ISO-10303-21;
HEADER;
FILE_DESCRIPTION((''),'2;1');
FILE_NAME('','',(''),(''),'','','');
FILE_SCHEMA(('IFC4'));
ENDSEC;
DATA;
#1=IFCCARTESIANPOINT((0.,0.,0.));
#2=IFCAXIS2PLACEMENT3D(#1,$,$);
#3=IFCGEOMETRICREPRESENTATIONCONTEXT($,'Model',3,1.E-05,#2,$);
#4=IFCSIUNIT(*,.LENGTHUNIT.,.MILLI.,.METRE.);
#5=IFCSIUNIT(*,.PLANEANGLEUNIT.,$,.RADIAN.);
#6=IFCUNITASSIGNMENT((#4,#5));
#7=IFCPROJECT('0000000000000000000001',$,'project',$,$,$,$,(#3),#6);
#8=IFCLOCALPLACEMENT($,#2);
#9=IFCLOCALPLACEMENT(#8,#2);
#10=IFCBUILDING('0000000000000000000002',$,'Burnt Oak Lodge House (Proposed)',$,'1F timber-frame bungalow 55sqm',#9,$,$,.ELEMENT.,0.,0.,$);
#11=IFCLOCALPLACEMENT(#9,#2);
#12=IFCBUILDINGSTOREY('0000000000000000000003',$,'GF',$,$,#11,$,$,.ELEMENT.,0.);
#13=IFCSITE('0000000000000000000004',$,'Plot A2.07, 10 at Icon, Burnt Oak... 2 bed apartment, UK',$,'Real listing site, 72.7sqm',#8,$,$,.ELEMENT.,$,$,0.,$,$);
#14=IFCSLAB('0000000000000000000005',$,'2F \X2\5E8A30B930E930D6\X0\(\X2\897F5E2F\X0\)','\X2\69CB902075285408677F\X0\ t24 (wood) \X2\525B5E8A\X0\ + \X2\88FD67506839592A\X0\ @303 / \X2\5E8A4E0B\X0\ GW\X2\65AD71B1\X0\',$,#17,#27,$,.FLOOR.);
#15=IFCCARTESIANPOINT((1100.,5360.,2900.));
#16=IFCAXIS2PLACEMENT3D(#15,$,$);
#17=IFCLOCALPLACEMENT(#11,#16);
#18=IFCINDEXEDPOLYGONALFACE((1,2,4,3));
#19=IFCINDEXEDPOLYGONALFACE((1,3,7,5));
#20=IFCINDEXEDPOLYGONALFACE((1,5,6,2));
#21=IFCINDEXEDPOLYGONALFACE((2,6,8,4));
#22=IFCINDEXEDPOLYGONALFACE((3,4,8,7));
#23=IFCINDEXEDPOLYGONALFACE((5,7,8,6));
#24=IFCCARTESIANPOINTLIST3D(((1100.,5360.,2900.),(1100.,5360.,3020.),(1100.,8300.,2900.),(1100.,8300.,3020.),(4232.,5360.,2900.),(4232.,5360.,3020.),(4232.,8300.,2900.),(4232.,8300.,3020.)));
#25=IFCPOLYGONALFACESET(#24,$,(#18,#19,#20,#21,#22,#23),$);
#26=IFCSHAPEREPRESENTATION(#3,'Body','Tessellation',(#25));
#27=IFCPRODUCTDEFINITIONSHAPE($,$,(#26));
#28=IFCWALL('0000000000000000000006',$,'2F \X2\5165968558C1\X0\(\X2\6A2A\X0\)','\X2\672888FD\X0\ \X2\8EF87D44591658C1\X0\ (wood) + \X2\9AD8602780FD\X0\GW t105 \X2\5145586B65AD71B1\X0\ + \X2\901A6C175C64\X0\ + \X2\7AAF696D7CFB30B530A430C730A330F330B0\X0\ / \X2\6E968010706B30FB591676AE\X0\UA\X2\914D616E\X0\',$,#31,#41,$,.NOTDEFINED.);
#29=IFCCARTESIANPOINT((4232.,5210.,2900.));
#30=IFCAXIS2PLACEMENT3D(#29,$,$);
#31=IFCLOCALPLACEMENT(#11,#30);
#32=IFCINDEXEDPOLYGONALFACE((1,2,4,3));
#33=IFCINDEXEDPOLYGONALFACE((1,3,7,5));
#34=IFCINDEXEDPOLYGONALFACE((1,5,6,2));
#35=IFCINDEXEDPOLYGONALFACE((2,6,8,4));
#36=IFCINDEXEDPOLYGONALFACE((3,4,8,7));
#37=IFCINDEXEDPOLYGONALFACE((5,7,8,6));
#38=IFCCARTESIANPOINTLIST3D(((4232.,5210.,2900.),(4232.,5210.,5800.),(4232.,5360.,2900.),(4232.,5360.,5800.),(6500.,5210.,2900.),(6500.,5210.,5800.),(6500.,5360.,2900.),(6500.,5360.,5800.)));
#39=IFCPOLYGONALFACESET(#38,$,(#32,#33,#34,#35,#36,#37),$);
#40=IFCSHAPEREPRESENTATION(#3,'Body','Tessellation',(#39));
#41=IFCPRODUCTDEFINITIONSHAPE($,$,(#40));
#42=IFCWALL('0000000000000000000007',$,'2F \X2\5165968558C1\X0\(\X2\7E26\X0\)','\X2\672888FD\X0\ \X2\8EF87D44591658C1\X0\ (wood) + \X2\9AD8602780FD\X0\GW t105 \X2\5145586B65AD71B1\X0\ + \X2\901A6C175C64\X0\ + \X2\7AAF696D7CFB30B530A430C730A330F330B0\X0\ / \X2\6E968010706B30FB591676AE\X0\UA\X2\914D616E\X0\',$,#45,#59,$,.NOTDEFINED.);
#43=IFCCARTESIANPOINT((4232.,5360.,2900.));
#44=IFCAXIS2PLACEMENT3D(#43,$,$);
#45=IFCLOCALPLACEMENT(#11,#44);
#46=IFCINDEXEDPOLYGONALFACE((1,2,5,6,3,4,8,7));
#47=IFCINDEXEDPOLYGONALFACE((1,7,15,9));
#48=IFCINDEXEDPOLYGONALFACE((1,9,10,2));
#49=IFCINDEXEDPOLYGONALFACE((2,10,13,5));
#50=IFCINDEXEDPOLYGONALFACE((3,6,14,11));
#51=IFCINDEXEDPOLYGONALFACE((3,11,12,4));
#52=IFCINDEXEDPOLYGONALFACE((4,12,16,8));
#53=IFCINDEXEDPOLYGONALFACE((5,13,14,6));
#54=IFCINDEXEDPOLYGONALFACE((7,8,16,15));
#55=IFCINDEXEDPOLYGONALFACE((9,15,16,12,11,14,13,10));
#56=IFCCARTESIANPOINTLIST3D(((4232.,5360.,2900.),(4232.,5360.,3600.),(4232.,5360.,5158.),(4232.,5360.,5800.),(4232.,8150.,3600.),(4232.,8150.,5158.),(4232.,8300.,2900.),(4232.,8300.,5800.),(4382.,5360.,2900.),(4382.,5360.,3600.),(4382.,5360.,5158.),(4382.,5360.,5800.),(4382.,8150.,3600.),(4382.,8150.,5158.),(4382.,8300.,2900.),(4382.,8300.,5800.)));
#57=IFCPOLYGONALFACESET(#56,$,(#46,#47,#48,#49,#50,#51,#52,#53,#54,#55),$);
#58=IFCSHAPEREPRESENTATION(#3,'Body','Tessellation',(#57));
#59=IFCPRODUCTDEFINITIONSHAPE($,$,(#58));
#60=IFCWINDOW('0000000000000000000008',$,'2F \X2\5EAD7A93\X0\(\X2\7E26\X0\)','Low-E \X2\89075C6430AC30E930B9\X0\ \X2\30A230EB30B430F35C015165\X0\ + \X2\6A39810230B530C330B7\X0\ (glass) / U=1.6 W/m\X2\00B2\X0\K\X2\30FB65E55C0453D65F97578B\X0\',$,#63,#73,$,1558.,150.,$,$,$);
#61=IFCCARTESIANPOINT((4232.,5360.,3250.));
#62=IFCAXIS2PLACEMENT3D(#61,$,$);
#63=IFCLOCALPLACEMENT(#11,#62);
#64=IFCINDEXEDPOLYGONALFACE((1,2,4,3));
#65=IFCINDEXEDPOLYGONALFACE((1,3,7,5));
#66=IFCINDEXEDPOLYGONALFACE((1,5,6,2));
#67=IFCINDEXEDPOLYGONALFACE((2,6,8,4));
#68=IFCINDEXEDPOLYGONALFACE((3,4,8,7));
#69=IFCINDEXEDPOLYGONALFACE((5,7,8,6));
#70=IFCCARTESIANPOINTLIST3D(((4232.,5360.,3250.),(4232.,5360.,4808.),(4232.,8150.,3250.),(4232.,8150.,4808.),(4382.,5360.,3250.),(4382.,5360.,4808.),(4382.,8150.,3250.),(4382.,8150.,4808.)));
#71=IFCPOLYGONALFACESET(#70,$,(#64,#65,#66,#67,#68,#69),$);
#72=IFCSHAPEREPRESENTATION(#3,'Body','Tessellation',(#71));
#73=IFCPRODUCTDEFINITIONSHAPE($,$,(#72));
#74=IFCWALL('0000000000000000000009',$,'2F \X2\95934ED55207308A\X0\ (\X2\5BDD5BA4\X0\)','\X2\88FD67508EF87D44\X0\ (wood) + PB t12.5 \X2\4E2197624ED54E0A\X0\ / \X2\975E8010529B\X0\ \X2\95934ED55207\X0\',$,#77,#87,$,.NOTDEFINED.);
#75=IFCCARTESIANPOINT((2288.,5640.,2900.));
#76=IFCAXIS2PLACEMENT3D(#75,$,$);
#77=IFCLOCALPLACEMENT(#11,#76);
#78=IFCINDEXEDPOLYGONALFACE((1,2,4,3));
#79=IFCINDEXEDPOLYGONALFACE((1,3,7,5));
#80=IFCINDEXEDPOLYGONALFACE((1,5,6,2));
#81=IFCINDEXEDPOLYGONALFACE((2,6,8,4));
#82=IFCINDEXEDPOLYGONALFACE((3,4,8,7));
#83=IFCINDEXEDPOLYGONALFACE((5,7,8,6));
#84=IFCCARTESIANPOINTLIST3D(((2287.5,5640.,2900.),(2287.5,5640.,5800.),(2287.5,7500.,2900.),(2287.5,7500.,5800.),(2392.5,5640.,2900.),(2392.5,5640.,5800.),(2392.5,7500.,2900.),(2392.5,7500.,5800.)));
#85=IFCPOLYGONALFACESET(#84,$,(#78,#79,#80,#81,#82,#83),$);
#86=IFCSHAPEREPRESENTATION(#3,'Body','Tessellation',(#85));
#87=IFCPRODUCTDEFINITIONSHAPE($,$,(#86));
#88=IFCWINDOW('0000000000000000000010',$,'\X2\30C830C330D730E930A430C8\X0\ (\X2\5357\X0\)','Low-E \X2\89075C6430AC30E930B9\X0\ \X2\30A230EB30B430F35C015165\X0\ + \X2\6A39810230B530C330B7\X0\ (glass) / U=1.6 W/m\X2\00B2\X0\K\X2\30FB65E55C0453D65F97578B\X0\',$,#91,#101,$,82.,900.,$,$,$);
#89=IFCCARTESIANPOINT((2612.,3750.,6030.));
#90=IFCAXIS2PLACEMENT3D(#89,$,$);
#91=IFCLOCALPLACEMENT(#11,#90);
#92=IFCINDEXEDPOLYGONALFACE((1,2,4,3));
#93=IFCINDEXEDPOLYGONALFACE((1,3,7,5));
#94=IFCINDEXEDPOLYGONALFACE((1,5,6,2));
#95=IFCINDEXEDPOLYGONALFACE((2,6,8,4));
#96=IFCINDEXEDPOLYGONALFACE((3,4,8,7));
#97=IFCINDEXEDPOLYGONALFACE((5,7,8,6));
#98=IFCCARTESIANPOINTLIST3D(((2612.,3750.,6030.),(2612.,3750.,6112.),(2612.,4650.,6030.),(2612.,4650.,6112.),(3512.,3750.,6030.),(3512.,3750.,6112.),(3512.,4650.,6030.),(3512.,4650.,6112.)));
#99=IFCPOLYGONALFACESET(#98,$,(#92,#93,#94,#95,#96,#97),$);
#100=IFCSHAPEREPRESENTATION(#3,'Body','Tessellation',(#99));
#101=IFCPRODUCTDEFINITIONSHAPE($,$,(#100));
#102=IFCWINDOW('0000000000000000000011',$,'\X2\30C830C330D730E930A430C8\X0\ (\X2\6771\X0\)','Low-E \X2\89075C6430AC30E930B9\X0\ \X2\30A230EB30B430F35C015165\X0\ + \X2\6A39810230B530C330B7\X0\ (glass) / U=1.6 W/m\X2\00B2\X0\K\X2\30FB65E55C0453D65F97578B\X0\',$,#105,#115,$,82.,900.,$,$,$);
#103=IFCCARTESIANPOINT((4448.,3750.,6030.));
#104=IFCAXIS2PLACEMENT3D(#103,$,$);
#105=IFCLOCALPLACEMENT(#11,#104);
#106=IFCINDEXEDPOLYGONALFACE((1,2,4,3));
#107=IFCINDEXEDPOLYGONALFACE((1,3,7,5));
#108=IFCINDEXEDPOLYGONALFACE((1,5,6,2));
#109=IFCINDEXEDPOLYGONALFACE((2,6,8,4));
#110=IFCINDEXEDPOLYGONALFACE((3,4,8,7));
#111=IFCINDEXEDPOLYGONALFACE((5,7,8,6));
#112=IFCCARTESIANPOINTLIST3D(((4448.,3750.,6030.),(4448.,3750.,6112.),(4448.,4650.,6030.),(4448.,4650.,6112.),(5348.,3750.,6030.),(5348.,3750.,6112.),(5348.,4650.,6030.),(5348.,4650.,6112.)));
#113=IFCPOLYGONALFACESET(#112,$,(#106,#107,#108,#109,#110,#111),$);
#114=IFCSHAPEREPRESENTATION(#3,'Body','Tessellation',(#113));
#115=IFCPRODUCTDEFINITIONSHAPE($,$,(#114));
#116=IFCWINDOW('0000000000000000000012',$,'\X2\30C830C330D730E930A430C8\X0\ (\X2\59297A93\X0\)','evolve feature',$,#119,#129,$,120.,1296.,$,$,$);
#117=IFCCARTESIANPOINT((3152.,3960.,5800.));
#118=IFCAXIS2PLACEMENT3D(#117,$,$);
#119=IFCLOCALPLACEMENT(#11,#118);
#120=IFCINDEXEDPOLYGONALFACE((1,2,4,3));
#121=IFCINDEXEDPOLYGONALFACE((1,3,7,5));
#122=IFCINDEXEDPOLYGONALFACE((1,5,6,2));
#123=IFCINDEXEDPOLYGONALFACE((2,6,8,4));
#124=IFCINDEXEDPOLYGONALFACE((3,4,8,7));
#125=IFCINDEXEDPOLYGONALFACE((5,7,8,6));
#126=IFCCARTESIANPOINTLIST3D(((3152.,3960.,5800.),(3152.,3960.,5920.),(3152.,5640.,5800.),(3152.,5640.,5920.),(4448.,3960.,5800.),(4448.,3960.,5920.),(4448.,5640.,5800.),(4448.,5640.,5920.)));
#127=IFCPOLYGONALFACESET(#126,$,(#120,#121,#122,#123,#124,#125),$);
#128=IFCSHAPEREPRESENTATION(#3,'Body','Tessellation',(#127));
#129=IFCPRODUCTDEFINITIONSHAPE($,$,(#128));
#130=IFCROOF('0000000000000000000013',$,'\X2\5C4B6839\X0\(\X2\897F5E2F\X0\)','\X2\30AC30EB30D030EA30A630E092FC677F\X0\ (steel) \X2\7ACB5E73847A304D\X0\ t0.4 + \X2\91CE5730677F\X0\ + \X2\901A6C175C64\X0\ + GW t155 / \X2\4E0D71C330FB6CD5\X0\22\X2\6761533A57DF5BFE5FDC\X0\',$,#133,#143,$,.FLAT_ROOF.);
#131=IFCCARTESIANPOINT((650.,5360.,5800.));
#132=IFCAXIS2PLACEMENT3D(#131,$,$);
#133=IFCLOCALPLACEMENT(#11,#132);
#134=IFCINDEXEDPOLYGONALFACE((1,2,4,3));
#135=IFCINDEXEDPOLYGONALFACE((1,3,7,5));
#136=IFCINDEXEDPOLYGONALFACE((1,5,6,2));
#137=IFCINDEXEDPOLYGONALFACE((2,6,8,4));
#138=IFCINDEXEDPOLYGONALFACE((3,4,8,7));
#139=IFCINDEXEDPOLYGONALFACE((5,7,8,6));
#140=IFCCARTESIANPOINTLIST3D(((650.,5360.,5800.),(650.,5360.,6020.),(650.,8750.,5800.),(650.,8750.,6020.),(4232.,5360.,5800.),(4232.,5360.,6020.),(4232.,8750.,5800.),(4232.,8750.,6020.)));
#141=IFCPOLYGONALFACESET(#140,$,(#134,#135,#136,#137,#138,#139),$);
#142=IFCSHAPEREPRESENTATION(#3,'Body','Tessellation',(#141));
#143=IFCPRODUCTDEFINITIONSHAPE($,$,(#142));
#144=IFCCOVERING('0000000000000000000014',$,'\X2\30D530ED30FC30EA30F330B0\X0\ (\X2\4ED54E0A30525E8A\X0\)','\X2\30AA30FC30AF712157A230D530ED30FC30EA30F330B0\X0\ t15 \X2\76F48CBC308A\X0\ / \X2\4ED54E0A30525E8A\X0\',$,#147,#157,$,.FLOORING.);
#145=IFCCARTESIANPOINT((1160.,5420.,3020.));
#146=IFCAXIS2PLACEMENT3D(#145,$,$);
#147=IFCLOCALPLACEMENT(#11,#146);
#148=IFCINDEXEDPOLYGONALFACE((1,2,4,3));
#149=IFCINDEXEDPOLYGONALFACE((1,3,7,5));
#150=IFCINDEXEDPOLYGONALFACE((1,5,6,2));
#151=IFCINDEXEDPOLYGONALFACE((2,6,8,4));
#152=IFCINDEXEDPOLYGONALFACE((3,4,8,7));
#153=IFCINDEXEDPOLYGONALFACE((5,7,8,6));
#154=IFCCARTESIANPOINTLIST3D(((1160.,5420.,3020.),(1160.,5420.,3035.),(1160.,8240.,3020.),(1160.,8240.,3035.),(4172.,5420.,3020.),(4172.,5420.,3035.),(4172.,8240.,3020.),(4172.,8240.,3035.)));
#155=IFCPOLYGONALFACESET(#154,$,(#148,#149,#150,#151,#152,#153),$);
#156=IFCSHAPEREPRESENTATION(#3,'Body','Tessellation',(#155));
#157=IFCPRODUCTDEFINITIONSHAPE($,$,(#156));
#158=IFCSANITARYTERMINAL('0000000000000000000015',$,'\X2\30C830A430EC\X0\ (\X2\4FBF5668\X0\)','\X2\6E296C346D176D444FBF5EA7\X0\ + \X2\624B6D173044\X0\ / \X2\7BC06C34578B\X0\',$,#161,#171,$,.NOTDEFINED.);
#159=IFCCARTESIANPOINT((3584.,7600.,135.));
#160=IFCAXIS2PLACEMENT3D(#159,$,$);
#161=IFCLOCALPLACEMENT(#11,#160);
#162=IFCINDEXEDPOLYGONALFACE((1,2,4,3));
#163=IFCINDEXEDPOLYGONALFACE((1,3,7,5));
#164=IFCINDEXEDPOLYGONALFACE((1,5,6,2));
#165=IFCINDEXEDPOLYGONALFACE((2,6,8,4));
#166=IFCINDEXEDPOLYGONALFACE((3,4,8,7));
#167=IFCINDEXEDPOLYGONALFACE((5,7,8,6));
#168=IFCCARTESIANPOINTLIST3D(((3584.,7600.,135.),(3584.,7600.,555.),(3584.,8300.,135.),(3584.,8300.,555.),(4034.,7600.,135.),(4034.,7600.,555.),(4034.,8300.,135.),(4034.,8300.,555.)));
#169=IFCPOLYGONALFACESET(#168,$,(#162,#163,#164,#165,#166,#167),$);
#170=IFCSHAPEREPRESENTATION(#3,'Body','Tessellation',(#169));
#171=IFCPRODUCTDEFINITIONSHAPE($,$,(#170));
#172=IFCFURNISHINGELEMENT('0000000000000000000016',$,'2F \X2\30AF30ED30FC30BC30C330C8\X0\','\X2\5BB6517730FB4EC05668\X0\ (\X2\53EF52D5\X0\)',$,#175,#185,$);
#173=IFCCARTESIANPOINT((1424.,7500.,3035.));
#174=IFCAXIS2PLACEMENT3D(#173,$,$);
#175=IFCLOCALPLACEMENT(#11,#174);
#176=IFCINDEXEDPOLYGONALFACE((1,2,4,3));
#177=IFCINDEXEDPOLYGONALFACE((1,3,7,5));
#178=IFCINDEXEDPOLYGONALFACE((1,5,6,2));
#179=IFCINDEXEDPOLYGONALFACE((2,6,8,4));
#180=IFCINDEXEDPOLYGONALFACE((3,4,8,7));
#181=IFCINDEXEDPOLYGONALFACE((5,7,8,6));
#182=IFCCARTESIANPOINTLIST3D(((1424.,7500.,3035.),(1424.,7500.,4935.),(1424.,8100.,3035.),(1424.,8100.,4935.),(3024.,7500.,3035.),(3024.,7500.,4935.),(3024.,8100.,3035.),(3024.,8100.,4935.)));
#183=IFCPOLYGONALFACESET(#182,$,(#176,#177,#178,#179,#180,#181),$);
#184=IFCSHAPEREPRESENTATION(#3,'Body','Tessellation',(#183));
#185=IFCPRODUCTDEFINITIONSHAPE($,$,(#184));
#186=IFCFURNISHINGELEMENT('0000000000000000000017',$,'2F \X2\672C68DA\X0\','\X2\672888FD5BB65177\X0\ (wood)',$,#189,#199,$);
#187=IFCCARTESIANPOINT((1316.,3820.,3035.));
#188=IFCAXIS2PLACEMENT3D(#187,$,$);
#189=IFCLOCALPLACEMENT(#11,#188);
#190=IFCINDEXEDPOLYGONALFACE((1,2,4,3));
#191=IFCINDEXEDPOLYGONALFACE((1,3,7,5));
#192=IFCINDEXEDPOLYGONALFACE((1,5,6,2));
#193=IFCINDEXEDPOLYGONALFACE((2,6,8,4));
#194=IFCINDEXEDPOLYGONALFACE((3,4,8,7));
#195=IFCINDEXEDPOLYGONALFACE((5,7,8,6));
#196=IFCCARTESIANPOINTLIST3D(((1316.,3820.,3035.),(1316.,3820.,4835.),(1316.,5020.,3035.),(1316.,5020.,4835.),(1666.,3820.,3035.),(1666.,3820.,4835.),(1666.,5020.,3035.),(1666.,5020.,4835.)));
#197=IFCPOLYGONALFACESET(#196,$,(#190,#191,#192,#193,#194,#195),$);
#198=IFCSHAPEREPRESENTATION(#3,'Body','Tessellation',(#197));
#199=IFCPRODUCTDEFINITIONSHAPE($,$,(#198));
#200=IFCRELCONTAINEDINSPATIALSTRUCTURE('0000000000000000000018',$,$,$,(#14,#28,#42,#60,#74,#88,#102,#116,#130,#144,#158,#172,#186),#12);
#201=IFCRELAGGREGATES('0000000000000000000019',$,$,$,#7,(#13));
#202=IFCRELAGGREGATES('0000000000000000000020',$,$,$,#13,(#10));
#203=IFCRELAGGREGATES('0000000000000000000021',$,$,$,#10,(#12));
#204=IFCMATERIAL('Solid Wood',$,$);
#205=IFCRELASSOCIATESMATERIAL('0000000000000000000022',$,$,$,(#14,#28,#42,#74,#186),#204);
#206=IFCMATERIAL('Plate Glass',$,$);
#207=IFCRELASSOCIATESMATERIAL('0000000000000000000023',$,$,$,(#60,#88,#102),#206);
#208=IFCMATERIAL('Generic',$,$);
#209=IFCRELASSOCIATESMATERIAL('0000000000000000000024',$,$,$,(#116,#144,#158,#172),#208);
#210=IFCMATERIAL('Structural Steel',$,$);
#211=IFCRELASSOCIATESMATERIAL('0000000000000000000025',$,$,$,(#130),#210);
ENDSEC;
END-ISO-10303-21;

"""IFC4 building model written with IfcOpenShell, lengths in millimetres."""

from ifc_helpers import new_model, si_unit, frame, frame_2d, origin, place, context, project, spatial, rectangle, extrude, material, element, fill, save


model = new_model("IFC4")

# Units and contexts
model_context = context("Model", 3, precision=1e-05, world=origin())
ifc_project = project(units=[si_unit("LENGTHUNIT", "METRE", prefix="MILLI"), si_unit("PLANEANGLEUNIT", "RADIAN")], contexts=[model_context])

# Site, building, storey
site_placement = place(None, origin())
site = spatial("IfcSite", under=ifc_project, at=site_placement, Name="Plot A2.07, 10 at Icon, Burnt Oak... 2 bed apartment, UK", ObjectType="Real listing site, 72.7sqm", CompositionType="ELEMENT", RefElevation=0.0)
building_placement = place(site_placement, origin())
building = spatial("IfcBuilding", under=site, at=building_placement, Name="Burnt Oak Lodge House (Proposed)", ObjectType="1F timber-frame bungalow 55sqm", CompositionType="ELEMENT", ElevationOfRefHeight=0.0, ElevationOfTerrain=0.0)
storey_placement = place(building_placement, origin())
storey = spatial("IfcBuildingStorey", under=building, at=storey_placement, Name="GF", CompositionType="ELEMENT", Elevation=0.0)

# Slab
ifc_material_1 = material(Name="Solid Wood")
slab_placement = place(storey_placement, frame((1100.0, 5360.0, 2900.0)))
element("IfcSlab", 1, at=slab_placement, inside=storey, material=ifc_material_1, Name="2F 床スラブ(西帯)", Description="構造用合板 t24 (wood) 剛床 + 製材根太 @303 / 床下 GW断熱", PredefinedType="FLOOR", context=model_context, shape_type="SweptSolid", body=[
    extrude(rectangle(XDim=3132.0, YDim=2940.0, at=frame_2d((1566.0, 1470.0))), frame((1100.0, 5360.0, 2900.0)), (0.0, 0.0, 1.0), 120.0),
])

# Shared definitions
ifc_material_2 = material(Name="Plate Glass")

# Wall
wall_1_placement = place(storey_placement, frame((4232.0, 5210.0, 2900.0)))
element("IfcWall", 2, at=wall_1_placement, inside=storey, material=ifc_material_1, Name="2F 入隅壁(横)", Description="木製 軸組外壁 (wood) + 高性能GW t105 充填断熱 + 通気層 + 窯業系サイディング / 準耐火・外皮UA配慮", PredefinedType="NOTDEFINED", context=model_context, shape_type="SweptSolid", body=[
    extrude(rectangle(XDim=2268.0, YDim=150.0, at=frame_2d((1134.0, 75.0))), frame((4232.0, 5210.0, 2900.0)), (0.0, 0.0, 1.0), 2900.0),
])

# Wall, opening, window
wall_2_placement = place(storey_placement, frame((4232.0, 5360.0, 2900.0)))
wall_2 = element("IfcWall", 3, at=wall_2_placement, inside=storey, material=ifc_material_1, Name="2F 入隅壁(縦)", Description="木製 軸組外壁 (wood) + 高性能GW t105 充填断熱 + 通気層 + 窯業系サイディング / 準耐火・外皮UA配慮", PredefinedType="NOTDEFINED", context=model_context, shape_type="SweptSolid", body=[
    extrude(rectangle(XDim=150.0, YDim=2940.0, at=frame_2d((75.0, 1470.0))), frame((4232.0, 5360.0, 2900.0)), (0.0, 0.0, 1.0), 2900.0),
])
opening_1_placement = place(storey_placement, frame((4232.0, 5360.0, 3250.0)))
opening_1 = element("IfcOpeningElement", 4, at=opening_1_placement, cuts=wall_2, PredefinedType="NOTDEFINED", context=model_context, shape_type="SweptSolid", body=[
    extrude(rectangle(XDim=150.0, YDim=2790.0, at=frame_2d((75.0, 1395.0))), frame((4232.0, 5360.0, 3250.0)), (0.0, 0.0, 1.0), 1558.0),
])
window_1_placement = place(storey_placement, frame((4232.0, 5360.0, 3250.0)))
window_1 = element("IfcWindow", 5, at=window_1_placement, inside=storey, material=ifc_material_2, Name="2F 庭窓(縦)", Description="Low-E 複層ガラス アルゴン封入 + 樹脂サッシ (glass) / U=1.6 W/m²K・日射取得型", OverallHeight=1558.0, OverallWidth=150.0, context=model_context, shape_type="SweptSolid", body=[
    extrude(rectangle(XDim=150.0, YDim=2790.0, at=frame_2d((75.0, 1395.0))), frame((4232.0, 5360.0, 3250.0)), (0.0, 0.0, 1.0), 1558.0),
])
fill(opening_1, window_1)

# Wall
wall_3_placement = place(storey_placement, frame((2288.0, 5640.0, 2900.0)))
element("IfcWall", 6, at=wall_3_placement, inside=storey, material=ifc_material_1, Name="2F 間仕切り (寝室)", Description="製材軸組 (wood) + PB t12.5 両面仕上 / 非耐力 間仕切", PredefinedType="NOTDEFINED", context=model_context, shape_type="SweptSolid", body=[
    extrude(rectangle(XDim=105.0, YDim=1860.0, at=frame_2d((52.0, 930.0))), frame((2288.0, 5640.0, 2900.0)), (0.0, 0.0, 1.0), 2900.0),
])

# Windows
window_2_placement = place(storey_placement, frame((2612.0, 3750.0, 6030.0)))
element("IfcWindow", 7, at=window_2_placement, inside=storey, material=ifc_material_2, Name="トップライト (南)", Description="Low-E 複層ガラス アルゴン封入 + 樹脂サッシ (glass) / U=1.6 W/m²K・日射取得型", OverallHeight=82.0, OverallWidth=900.0, context=model_context, shape_type="SweptSolid", body=[
    extrude(rectangle(XDim=900.0, YDim=900.0, at=frame_2d((450.0, 450.0))), frame((2612.0, 3750.0, 6030.0)), (0.0, 0.0, 1.0), 82.0),
])
window_3_placement = place(storey_placement, frame((4448.0, 3750.0, 6030.0)))
element("IfcWindow", 8, at=window_3_placement, inside=storey, material=ifc_material_2, Name="トップライト (東)", Description="Low-E 複層ガラス アルゴン封入 + 樹脂サッシ (glass) / U=1.6 W/m²K・日射取得型", OverallHeight=82.0, OverallWidth=900.0, context=model_context, shape_type="SweptSolid", body=[
    extrude(rectangle(XDim=900.0, YDim=900.0, at=frame_2d((450.0, 450.0))), frame((4448.0, 3750.0, 6030.0)), (0.0, 0.0, 1.0), 82.0),
])
ifc_material_3 = material(Name="Generic")
window_4_placement = place(storey_placement, frame((3152.0, 3960.0, 5800.0)))
element("IfcWindow", 9, at=window_4_placement, inside=storey, material=ifc_material_3, Name="トップライト (天窓)", Description="evolve feature", OverallHeight=120.0, OverallWidth=1296.0, context=model_context, shape_type="SweptSolid", body=[
    extrude(rectangle(XDim=1296.0, YDim=1680.0, at=frame_2d((648.0, 840.0))), frame((3152.0, 3960.0, 5800.0)), (0.0, 0.0, 1.0), 120.0),
])

# Roof
ifc_material_4 = material(Name="Structural Steel")
for number, where, name in (
    (10, (650.0, 5360.0, 5800.0), "屋根(西帯)"),
):
    element("IfcRoof", number, at=place(storey_placement, frame(where)), inside=storey, material=ifc_material_4, Name=name, Description="ガルバリウム鋼板 (steel) 立平葺き t0.4 + 野地板 + 通気層 + GW t155 / 不燃・法22条区域対応", PredefinedType="FLAT_ROOF", context=model_context, shape_type="SweptSolid", body=[
        extrude(rectangle(XDim=3582.0, YDim=3390.0, at=frame_2d((1791.0, 1695.0))), frame((650.0, 5360.0, 5800.0)), (0.0, 0.0, 1.0), 220.0),
    ])

# Covering
covering_placement = place(storey_placement, frame((1160.0, 5420.0, 3020.0)))
element("IfcCovering", 11, at=covering_placement, inside=storey, material=ifc_material_3, Name="フローリング (仕上げ床)", Description="オーク無垢フローリング t15 直貼り / 仕上げ床", PredefinedType="FLOORING", context=model_context, shape_type="SweptSolid", body=[
    extrude(rectangle(XDim=3012.0, YDim=2820.0, at=frame_2d((1506.0, 1410.0))), frame((1160.0, 5420.0, 3020.0)), (0.0, 0.0, 1.0), 15.0),
])

# Sanitary terminal
sanitary_terminal_placement = place(storey_placement, frame((3584.0, 7600.0, 135.0)))
element("IfcSanitaryTerminal", 12, at=sanitary_terminal_placement, inside=storey, material=ifc_material_3, Name="トイレ (便器)", Description="温水洗浄便座 + 手洗い / 節水型", PredefinedType="NOTDEFINED", context=model_context, shape_type="SweptSolid", body=[
    extrude(rectangle(XDim=450.0, YDim=700.0, at=frame_2d((225.0, 350.0))), frame((3584.0, 7600.0, 135.0)), (0.0, 0.0, 1.0), 420.0),
])

# Furnishing elements
furnishing_1_placement = place(storey_placement, frame((1424.0, 7500.0, 3035.0)))
element("IfcFurnishingElement", 13, at=furnishing_1_placement, inside=storey, material=ifc_material_3, Name="2F クローゼット", Description="家具・什器 (可動)", context=model_context, shape_type="SweptSolid", body=[
    extrude(rectangle(XDim=1600.0, YDim=600.0, at=frame_2d((800.0, 300.0))), frame((1424.0, 7500.0, 3035.0)), (0.0, 0.0, 1.0), 1900.0),
])
furnishing_2_placement = place(storey_placement, frame((1316.0, 3820.0, 3035.0)))
element("IfcFurnishingElement", 14, at=furnishing_2_placement, inside=storey, material=ifc_material_1, Name="2F 本棚", Description="木製家具 (wood)", context=model_context, shape_type="SweptSolid", body=[
    extrude(rectangle(XDim=350.0, YDim=1200.0, at=frame_2d((175.0, 600.0))), frame((1316.0, 3820.0, 3035.0)), (0.0, 0.0, 1.0), 1800.0),
])

save(model, "model.ifc")
